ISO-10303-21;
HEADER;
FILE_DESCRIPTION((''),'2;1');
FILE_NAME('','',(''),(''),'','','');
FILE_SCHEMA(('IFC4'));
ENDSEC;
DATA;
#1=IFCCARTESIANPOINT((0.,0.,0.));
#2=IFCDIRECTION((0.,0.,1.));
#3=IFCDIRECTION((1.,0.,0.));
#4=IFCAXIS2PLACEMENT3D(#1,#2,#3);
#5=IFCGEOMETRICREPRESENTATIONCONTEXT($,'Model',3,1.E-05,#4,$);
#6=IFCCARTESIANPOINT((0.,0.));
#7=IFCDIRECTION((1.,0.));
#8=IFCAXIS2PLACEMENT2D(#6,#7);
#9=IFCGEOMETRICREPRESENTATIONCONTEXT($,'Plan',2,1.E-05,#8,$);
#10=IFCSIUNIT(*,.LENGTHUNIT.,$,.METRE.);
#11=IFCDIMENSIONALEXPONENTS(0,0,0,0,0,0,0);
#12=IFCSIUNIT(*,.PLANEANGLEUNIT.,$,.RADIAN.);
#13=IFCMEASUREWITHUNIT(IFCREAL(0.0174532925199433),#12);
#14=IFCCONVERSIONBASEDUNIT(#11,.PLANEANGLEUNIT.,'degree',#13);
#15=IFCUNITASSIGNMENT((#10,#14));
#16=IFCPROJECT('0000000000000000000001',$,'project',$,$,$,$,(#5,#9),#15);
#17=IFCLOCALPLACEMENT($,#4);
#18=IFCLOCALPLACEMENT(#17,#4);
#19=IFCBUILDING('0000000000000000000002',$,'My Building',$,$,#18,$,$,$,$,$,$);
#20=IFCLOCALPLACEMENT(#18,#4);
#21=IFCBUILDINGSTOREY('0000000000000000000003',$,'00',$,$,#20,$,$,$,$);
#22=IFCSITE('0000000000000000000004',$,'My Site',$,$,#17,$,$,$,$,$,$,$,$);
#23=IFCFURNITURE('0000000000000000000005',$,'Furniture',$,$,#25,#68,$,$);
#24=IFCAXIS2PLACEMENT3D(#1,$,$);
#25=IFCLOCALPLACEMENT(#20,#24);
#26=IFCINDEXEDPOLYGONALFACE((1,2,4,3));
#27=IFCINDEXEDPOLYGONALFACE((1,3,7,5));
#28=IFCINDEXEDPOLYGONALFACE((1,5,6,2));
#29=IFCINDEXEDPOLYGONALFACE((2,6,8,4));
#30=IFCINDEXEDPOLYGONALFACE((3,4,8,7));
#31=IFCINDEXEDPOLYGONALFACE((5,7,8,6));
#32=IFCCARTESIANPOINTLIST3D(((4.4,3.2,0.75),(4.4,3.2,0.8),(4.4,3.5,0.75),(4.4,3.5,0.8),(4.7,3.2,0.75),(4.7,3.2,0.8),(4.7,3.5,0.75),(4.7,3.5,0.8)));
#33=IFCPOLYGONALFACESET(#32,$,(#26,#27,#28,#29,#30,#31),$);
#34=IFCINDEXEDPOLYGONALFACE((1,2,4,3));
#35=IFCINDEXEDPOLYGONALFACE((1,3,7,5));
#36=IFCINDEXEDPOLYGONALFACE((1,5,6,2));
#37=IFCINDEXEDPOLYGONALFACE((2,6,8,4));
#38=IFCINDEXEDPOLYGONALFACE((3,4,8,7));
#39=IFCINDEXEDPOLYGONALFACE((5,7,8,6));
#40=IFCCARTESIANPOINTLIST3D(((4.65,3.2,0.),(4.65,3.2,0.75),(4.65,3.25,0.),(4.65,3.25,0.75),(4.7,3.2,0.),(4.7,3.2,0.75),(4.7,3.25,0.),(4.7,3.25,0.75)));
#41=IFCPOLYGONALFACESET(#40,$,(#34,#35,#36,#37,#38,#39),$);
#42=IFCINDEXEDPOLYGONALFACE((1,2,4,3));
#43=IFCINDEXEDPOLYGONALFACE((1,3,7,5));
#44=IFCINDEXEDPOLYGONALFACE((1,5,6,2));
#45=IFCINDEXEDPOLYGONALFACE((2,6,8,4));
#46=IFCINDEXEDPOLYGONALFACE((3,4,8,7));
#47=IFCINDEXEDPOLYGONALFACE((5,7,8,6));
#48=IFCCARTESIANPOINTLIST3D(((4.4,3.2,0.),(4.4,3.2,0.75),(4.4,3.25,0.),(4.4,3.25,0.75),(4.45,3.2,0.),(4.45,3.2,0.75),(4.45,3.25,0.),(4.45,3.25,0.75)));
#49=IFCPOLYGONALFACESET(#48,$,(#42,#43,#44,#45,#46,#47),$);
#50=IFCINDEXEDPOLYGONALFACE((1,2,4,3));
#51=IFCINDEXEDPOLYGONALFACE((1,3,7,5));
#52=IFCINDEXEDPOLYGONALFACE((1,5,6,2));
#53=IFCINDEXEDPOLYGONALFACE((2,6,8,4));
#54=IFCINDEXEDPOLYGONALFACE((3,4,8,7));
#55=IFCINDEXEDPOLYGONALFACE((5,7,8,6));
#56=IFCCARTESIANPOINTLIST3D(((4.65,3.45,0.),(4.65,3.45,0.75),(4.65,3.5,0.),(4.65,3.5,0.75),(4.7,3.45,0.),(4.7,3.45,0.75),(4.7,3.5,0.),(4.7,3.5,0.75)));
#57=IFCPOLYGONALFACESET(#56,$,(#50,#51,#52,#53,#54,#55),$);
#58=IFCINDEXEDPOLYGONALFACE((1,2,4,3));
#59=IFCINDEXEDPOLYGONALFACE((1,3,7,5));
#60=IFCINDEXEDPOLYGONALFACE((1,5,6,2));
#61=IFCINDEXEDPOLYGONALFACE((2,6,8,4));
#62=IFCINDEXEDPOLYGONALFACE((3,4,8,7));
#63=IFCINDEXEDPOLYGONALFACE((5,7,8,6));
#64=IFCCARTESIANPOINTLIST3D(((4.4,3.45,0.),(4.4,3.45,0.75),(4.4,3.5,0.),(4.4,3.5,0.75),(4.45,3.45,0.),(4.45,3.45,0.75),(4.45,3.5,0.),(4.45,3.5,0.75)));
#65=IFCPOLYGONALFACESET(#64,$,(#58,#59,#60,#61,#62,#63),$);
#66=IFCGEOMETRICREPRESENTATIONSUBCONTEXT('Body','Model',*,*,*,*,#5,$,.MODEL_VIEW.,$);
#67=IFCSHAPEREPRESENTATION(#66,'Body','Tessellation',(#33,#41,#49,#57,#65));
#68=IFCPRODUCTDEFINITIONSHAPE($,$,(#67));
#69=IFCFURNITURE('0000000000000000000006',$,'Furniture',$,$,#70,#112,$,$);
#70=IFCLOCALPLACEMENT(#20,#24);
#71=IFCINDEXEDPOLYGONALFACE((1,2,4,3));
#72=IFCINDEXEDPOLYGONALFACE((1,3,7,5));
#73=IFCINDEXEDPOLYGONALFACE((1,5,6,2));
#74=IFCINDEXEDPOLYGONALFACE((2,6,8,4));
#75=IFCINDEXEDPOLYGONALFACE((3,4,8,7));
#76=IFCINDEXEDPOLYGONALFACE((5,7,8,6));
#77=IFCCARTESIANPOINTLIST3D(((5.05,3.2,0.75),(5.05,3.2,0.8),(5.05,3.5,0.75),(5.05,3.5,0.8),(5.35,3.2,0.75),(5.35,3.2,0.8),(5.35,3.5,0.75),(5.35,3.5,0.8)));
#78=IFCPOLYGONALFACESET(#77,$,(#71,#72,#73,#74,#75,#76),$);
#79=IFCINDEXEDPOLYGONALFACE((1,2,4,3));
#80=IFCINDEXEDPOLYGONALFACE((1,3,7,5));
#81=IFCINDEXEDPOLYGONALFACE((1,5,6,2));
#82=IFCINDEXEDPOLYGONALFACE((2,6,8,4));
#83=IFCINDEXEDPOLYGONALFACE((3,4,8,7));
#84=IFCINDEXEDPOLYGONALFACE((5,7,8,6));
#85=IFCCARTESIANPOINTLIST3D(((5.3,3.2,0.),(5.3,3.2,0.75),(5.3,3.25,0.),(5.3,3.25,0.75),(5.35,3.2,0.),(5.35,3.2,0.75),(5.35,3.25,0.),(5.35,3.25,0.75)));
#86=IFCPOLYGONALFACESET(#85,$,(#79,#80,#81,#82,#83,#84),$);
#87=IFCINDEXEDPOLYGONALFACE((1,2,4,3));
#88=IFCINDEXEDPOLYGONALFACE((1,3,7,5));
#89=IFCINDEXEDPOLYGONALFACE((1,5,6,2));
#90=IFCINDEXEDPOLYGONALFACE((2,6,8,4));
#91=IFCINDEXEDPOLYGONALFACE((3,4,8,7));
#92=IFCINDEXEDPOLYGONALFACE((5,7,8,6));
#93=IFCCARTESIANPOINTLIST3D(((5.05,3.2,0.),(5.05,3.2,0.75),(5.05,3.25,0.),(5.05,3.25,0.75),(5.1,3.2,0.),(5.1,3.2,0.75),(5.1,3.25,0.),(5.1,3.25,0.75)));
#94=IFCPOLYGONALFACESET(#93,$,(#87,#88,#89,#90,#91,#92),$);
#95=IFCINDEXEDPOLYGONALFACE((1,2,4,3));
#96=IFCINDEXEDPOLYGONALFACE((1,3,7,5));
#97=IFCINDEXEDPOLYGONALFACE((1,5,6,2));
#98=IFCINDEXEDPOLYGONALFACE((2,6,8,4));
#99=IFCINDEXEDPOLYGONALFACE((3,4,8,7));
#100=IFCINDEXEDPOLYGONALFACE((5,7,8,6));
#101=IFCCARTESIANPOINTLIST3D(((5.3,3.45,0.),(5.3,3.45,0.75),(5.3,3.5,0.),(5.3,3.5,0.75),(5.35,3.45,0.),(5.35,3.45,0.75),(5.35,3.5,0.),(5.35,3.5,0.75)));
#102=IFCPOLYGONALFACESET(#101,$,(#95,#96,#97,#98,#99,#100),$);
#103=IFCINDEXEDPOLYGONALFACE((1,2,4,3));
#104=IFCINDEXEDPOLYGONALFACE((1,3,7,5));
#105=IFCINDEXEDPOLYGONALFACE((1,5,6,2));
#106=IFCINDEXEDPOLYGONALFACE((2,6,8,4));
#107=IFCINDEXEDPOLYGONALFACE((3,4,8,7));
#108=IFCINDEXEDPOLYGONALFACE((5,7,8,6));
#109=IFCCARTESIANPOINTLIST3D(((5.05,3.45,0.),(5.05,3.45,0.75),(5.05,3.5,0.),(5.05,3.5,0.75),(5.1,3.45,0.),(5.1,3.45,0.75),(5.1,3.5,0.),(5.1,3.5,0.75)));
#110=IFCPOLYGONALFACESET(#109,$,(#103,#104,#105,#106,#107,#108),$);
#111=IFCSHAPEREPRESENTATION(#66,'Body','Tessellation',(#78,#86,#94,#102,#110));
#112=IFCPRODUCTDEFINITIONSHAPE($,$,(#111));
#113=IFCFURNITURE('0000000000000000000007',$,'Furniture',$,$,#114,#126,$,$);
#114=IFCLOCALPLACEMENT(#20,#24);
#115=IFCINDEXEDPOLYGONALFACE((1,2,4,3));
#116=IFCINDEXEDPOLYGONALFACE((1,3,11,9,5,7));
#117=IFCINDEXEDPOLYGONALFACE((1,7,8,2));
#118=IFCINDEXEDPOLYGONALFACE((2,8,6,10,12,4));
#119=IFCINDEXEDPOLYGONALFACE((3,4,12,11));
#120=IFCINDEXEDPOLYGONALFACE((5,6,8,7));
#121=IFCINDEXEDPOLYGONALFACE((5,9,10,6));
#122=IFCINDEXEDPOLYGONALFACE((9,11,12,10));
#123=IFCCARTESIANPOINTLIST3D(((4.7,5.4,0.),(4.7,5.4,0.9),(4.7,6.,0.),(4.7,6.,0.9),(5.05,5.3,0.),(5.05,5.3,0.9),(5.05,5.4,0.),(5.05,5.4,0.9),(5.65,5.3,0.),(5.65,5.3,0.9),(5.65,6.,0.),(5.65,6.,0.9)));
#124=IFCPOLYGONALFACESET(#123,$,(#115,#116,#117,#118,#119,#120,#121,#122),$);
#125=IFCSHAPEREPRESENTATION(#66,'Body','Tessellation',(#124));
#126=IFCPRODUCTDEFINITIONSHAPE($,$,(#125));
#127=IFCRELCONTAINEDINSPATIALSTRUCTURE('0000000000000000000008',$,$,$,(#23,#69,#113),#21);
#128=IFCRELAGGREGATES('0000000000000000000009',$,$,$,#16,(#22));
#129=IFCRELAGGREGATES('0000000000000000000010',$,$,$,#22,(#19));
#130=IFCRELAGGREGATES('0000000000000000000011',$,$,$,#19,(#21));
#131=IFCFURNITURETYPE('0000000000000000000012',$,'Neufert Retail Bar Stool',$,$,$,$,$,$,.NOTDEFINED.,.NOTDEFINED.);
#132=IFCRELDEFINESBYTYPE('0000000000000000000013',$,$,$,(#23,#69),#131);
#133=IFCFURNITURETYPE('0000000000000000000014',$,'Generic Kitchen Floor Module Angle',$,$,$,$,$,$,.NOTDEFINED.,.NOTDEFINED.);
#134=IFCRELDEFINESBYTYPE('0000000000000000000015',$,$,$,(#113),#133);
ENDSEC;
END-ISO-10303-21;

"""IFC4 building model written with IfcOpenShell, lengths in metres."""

from ifc_helpers import new_model, entity, si_unit, converted_unit, frame, origin_with_axes, origin_2d_with_axis, place, context, subcontext, project, spatial, line, indexed_curve, outline, extrude, shape, source, transform, mapped, type_object, type_shapes, element, save


model = new_model("IFC4")

# Units and contexts
model_context = context("Model", 3, precision=1e-05, world=origin_with_axes())
plan_context = context("Plan", 2, precision=1e-05, world=origin_2d_with_axis())
body_context_1 = subcontext(model_context, "Body", "Model", "MODEL_VIEW")
body_context_2 = subcontext(plan_context, "Body", "Plan", "PLAN_VIEW")
ifc_project = project(units=[si_unit("LENGTHUNIT", "METRE"), converted_unit("PLANEANGLEUNIT", "degree", entity("IfcReal", 0.0174532925199433), si_unit("PLANEANGLEUNIT", "RADIAN"), dimensions=[0, 0, 0, 0, 0, 0, 0])], contexts=[model_context, plan_context])

# Site, building, storey
site_placement = place(None, origin_with_axes())
site = spatial("IfcSite", under=ifc_project, at=site_placement, Name="My Site")
building_placement = place(site_placement, origin_with_axes())
building = spatial("IfcBuilding", under=site, at=building_placement, Name="My Building")
storey_placement = place(building_placement, origin_with_axes())
storey = spatial("IfcBuildingStorey", under=building, at=storey_placement, Name="00")

# Furniture
furniture_type_1 = type_object("IfcFurnitureType", Name="Neufert Retail Bar Stool", AssemblyPlace="NOTDEFINED", PredefinedType="NOTDEFINED")
shared_shape_1 = source(origin_with_axes(), body_context_1, "Body", "SweptSolid", [
    extrude(outline(indexed_curve([(-0.15, 0.0), (0.15, 0.0), (0.15, -0.3), (-0.15, -0.3)], segments=[line(1, 2, 3, 4, 1)])), frame((0.0, 0.0, 0.8), z_axis=(0.0, 0.0, 1.0), x_axis=(1.0, 0.0, 0.0)), (0.0, 0.0, -1.0), 0.05),
    extrude(outline(indexed_curve([(-0.15, 0.0), (-0.1, 0.0), (-0.1, -0.05), (-0.15, -0.05)], segments=[line(1, 2, 3, 4, 1)])), origin_with_axes(), (0.0, 0.0, 1.0), 0.75),
    extrude(outline(indexed_curve([(0.15, 0.0), (0.1, 0.0), (0.1, -0.05), (0.15, -0.05)], segments=[line(1, 2, 3, 4, 1)])), origin_with_axes(), (0.0, 0.0, 1.0), 0.75),
    extrude(outline(indexed_curve([(-0.15, -0.3), (-0.1, -0.3), (-0.1, -0.25), (-0.15, -0.25)], segments=[line(1, 2, 3, 4, 1)])), origin_with_axes(), (0.0, 0.0, 1.0), 0.75),
    extrude(outline(indexed_curve([(0.15, -0.3), (0.1, -0.3), (0.1, -0.25), (0.15, -0.25)], segments=[line(1, 2, 3, 4, 1)])), origin_with_axes(), (0.0, 0.0, 1.0), 0.75),
])
shared_shape_2 = source(origin_with_axes(), body_context_2, "Body", "Curve2D", [
    entity("IfcIndexedPolyCurve", entity("IfcCartesianPointList2D", [[-0.15, -0.3], [0.15, -0.3]])),
    entity("IfcIndexedPolyCurve", entity("IfcCartesianPointList2D", [[-0.15, -0.3], [-0.15, -0.15], [-0.1061, -0.0439], [0.0, 0.0], [0.1061, -0.0439], [0.15, -0.15], [0.15, -0.3]]), [entity("IfcLineIndex", [1, 2]), entity("IfcArcIndex", [2, 3, 4]), entity("IfcArcIndex", [4, 5, 6]), entity("IfcLineIndex", [6, 7])]),
    entity("IfcIndexedPolyCurve", entity("IfcCartesianPointList2D", [[-0.12, -0.3], [-0.12, -0.15], [-0.0849, -0.0651], [0.0, -0.03], [0.0849, -0.0651], [0.12, -0.15], [0.12, -0.3]]), [entity("IfcLineIndex", [1, 2]), entity("IfcArcIndex", [2, 3, 4]), entity("IfcArcIndex", [4, 5, 6]), entity("IfcLineIndex", [6, 7])]),
])
type_shapes(furniture_type_1, [shared_shape_1, shared_shape_2])
for number, where, z_axis, x_axis, name in (
    (1, (4.55, 3.2, 0.0), (0.0, 0.0, 1.0), (-1.0, 0.0, 0.0), "Furniture"),
    (2, (5.2, 3.2, 0.0), (0.0, 0.0, 1.0), (-1.0, 0.0, 0.0), "Furniture"),
):
    element("IfcFurniture", number, at=place(storey_placement, frame(where, z_axis=z_axis, x_axis=x_axis)), inside=storey, type_object=furniture_type_1, Name=name, shapes=[
        shape(body_context_1, "Body", "MappedRepresentation", [mapped(shared_shape_1, transform((0.0, 0.0, 0.0), x_axis=(1.0, 0.0, 0.0), y_axis=(0.0, 1.0, 0.0), z_axis=(0.0, 0.0, 1.0), scale=1.0))]),
        shape(body_context_2, "Body", "MappedRepresentation", [mapped(shared_shape_2, transform((0.0, 0.0, 0.0), x_axis=(1.0, 0.0, 0.0), y_axis=(0.0, 1.0, 0.0), z_axis=(0.0, 0.0, 1.0), scale=1.0))]),
    ])
furniture_type_2 = type_object("IfcFurnitureType", Name="Generic Kitchen Floor Module Angle", AssemblyPlace="NOTDEFINED", PredefinedType="NOTDEFINED")
shared_shape_3 = source(origin_with_axes(), body_context_1, "Body", "SweptSolid", [
    extrude(outline(indexed_curve([(0.95, 0.6), (0.95, -0.1), (0.0, 0.0), (0.0, 0.6), (0.35, -0.1), (0.35, 0.0)], segments=[line(3, 6), line(6, 5), line(5, 2), line(2, 1), line(1, 4), line(4, 3)], self_intersect=False)), origin_with_axes(), (0.0, 0.0, 1.0), 0.9),
])
shared_shape_4 = source(origin_with_axes(), body_context_2, "Body", "Annotation2D", [
    entity("IfcGeometricCurveSet", [entity("IfcIndexedPolyCurve", entity("IfcCartesianPointList2D", [[0.0, 0.0], [0.35, 0.0], [0.35, -0.1], [0.95, -0.1], [0.95, 0.6], [0.0, 0.6]]), [entity("IfcLineIndex", [1, 2, 3, 4, 5, 6, 1])])]),
])
type_shapes(furniture_type_2, [shared_shape_3, shared_shape_4])
furniture_1_placement = place(storey_placement, frame((4.7, 5.4, 0.0), z_axis=(0.0, 0.0, 1.0), x_axis=(1.0, 0.0, 0.0)))
element("IfcFurniture", 3, at=furniture_1_placement, inside=storey, type_object=furniture_type_2, Name="Furniture", shapes=[
    shape(body_context_1, "Body", "MappedRepresentation", [mapped(shared_shape_3, transform((0.0, 0.0, 0.0), x_axis=(1.0, 0.0, 0.0), y_axis=(0.0, 1.0, 0.0), z_axis=(0.0, 0.0, 1.0), scale=1.0))]),
    shape(body_context_2, "Body", "MappedRepresentation", [mapped(shared_shape_4, transform((0.0, 0.0, 0.0), x_axis=(1.0, 0.0, 0.0), y_axis=(0.0, 1.0, 0.0), z_axis=(0.0, 0.0, 1.0), scale=1.0))]),
])

save(model, "model.ifc")
